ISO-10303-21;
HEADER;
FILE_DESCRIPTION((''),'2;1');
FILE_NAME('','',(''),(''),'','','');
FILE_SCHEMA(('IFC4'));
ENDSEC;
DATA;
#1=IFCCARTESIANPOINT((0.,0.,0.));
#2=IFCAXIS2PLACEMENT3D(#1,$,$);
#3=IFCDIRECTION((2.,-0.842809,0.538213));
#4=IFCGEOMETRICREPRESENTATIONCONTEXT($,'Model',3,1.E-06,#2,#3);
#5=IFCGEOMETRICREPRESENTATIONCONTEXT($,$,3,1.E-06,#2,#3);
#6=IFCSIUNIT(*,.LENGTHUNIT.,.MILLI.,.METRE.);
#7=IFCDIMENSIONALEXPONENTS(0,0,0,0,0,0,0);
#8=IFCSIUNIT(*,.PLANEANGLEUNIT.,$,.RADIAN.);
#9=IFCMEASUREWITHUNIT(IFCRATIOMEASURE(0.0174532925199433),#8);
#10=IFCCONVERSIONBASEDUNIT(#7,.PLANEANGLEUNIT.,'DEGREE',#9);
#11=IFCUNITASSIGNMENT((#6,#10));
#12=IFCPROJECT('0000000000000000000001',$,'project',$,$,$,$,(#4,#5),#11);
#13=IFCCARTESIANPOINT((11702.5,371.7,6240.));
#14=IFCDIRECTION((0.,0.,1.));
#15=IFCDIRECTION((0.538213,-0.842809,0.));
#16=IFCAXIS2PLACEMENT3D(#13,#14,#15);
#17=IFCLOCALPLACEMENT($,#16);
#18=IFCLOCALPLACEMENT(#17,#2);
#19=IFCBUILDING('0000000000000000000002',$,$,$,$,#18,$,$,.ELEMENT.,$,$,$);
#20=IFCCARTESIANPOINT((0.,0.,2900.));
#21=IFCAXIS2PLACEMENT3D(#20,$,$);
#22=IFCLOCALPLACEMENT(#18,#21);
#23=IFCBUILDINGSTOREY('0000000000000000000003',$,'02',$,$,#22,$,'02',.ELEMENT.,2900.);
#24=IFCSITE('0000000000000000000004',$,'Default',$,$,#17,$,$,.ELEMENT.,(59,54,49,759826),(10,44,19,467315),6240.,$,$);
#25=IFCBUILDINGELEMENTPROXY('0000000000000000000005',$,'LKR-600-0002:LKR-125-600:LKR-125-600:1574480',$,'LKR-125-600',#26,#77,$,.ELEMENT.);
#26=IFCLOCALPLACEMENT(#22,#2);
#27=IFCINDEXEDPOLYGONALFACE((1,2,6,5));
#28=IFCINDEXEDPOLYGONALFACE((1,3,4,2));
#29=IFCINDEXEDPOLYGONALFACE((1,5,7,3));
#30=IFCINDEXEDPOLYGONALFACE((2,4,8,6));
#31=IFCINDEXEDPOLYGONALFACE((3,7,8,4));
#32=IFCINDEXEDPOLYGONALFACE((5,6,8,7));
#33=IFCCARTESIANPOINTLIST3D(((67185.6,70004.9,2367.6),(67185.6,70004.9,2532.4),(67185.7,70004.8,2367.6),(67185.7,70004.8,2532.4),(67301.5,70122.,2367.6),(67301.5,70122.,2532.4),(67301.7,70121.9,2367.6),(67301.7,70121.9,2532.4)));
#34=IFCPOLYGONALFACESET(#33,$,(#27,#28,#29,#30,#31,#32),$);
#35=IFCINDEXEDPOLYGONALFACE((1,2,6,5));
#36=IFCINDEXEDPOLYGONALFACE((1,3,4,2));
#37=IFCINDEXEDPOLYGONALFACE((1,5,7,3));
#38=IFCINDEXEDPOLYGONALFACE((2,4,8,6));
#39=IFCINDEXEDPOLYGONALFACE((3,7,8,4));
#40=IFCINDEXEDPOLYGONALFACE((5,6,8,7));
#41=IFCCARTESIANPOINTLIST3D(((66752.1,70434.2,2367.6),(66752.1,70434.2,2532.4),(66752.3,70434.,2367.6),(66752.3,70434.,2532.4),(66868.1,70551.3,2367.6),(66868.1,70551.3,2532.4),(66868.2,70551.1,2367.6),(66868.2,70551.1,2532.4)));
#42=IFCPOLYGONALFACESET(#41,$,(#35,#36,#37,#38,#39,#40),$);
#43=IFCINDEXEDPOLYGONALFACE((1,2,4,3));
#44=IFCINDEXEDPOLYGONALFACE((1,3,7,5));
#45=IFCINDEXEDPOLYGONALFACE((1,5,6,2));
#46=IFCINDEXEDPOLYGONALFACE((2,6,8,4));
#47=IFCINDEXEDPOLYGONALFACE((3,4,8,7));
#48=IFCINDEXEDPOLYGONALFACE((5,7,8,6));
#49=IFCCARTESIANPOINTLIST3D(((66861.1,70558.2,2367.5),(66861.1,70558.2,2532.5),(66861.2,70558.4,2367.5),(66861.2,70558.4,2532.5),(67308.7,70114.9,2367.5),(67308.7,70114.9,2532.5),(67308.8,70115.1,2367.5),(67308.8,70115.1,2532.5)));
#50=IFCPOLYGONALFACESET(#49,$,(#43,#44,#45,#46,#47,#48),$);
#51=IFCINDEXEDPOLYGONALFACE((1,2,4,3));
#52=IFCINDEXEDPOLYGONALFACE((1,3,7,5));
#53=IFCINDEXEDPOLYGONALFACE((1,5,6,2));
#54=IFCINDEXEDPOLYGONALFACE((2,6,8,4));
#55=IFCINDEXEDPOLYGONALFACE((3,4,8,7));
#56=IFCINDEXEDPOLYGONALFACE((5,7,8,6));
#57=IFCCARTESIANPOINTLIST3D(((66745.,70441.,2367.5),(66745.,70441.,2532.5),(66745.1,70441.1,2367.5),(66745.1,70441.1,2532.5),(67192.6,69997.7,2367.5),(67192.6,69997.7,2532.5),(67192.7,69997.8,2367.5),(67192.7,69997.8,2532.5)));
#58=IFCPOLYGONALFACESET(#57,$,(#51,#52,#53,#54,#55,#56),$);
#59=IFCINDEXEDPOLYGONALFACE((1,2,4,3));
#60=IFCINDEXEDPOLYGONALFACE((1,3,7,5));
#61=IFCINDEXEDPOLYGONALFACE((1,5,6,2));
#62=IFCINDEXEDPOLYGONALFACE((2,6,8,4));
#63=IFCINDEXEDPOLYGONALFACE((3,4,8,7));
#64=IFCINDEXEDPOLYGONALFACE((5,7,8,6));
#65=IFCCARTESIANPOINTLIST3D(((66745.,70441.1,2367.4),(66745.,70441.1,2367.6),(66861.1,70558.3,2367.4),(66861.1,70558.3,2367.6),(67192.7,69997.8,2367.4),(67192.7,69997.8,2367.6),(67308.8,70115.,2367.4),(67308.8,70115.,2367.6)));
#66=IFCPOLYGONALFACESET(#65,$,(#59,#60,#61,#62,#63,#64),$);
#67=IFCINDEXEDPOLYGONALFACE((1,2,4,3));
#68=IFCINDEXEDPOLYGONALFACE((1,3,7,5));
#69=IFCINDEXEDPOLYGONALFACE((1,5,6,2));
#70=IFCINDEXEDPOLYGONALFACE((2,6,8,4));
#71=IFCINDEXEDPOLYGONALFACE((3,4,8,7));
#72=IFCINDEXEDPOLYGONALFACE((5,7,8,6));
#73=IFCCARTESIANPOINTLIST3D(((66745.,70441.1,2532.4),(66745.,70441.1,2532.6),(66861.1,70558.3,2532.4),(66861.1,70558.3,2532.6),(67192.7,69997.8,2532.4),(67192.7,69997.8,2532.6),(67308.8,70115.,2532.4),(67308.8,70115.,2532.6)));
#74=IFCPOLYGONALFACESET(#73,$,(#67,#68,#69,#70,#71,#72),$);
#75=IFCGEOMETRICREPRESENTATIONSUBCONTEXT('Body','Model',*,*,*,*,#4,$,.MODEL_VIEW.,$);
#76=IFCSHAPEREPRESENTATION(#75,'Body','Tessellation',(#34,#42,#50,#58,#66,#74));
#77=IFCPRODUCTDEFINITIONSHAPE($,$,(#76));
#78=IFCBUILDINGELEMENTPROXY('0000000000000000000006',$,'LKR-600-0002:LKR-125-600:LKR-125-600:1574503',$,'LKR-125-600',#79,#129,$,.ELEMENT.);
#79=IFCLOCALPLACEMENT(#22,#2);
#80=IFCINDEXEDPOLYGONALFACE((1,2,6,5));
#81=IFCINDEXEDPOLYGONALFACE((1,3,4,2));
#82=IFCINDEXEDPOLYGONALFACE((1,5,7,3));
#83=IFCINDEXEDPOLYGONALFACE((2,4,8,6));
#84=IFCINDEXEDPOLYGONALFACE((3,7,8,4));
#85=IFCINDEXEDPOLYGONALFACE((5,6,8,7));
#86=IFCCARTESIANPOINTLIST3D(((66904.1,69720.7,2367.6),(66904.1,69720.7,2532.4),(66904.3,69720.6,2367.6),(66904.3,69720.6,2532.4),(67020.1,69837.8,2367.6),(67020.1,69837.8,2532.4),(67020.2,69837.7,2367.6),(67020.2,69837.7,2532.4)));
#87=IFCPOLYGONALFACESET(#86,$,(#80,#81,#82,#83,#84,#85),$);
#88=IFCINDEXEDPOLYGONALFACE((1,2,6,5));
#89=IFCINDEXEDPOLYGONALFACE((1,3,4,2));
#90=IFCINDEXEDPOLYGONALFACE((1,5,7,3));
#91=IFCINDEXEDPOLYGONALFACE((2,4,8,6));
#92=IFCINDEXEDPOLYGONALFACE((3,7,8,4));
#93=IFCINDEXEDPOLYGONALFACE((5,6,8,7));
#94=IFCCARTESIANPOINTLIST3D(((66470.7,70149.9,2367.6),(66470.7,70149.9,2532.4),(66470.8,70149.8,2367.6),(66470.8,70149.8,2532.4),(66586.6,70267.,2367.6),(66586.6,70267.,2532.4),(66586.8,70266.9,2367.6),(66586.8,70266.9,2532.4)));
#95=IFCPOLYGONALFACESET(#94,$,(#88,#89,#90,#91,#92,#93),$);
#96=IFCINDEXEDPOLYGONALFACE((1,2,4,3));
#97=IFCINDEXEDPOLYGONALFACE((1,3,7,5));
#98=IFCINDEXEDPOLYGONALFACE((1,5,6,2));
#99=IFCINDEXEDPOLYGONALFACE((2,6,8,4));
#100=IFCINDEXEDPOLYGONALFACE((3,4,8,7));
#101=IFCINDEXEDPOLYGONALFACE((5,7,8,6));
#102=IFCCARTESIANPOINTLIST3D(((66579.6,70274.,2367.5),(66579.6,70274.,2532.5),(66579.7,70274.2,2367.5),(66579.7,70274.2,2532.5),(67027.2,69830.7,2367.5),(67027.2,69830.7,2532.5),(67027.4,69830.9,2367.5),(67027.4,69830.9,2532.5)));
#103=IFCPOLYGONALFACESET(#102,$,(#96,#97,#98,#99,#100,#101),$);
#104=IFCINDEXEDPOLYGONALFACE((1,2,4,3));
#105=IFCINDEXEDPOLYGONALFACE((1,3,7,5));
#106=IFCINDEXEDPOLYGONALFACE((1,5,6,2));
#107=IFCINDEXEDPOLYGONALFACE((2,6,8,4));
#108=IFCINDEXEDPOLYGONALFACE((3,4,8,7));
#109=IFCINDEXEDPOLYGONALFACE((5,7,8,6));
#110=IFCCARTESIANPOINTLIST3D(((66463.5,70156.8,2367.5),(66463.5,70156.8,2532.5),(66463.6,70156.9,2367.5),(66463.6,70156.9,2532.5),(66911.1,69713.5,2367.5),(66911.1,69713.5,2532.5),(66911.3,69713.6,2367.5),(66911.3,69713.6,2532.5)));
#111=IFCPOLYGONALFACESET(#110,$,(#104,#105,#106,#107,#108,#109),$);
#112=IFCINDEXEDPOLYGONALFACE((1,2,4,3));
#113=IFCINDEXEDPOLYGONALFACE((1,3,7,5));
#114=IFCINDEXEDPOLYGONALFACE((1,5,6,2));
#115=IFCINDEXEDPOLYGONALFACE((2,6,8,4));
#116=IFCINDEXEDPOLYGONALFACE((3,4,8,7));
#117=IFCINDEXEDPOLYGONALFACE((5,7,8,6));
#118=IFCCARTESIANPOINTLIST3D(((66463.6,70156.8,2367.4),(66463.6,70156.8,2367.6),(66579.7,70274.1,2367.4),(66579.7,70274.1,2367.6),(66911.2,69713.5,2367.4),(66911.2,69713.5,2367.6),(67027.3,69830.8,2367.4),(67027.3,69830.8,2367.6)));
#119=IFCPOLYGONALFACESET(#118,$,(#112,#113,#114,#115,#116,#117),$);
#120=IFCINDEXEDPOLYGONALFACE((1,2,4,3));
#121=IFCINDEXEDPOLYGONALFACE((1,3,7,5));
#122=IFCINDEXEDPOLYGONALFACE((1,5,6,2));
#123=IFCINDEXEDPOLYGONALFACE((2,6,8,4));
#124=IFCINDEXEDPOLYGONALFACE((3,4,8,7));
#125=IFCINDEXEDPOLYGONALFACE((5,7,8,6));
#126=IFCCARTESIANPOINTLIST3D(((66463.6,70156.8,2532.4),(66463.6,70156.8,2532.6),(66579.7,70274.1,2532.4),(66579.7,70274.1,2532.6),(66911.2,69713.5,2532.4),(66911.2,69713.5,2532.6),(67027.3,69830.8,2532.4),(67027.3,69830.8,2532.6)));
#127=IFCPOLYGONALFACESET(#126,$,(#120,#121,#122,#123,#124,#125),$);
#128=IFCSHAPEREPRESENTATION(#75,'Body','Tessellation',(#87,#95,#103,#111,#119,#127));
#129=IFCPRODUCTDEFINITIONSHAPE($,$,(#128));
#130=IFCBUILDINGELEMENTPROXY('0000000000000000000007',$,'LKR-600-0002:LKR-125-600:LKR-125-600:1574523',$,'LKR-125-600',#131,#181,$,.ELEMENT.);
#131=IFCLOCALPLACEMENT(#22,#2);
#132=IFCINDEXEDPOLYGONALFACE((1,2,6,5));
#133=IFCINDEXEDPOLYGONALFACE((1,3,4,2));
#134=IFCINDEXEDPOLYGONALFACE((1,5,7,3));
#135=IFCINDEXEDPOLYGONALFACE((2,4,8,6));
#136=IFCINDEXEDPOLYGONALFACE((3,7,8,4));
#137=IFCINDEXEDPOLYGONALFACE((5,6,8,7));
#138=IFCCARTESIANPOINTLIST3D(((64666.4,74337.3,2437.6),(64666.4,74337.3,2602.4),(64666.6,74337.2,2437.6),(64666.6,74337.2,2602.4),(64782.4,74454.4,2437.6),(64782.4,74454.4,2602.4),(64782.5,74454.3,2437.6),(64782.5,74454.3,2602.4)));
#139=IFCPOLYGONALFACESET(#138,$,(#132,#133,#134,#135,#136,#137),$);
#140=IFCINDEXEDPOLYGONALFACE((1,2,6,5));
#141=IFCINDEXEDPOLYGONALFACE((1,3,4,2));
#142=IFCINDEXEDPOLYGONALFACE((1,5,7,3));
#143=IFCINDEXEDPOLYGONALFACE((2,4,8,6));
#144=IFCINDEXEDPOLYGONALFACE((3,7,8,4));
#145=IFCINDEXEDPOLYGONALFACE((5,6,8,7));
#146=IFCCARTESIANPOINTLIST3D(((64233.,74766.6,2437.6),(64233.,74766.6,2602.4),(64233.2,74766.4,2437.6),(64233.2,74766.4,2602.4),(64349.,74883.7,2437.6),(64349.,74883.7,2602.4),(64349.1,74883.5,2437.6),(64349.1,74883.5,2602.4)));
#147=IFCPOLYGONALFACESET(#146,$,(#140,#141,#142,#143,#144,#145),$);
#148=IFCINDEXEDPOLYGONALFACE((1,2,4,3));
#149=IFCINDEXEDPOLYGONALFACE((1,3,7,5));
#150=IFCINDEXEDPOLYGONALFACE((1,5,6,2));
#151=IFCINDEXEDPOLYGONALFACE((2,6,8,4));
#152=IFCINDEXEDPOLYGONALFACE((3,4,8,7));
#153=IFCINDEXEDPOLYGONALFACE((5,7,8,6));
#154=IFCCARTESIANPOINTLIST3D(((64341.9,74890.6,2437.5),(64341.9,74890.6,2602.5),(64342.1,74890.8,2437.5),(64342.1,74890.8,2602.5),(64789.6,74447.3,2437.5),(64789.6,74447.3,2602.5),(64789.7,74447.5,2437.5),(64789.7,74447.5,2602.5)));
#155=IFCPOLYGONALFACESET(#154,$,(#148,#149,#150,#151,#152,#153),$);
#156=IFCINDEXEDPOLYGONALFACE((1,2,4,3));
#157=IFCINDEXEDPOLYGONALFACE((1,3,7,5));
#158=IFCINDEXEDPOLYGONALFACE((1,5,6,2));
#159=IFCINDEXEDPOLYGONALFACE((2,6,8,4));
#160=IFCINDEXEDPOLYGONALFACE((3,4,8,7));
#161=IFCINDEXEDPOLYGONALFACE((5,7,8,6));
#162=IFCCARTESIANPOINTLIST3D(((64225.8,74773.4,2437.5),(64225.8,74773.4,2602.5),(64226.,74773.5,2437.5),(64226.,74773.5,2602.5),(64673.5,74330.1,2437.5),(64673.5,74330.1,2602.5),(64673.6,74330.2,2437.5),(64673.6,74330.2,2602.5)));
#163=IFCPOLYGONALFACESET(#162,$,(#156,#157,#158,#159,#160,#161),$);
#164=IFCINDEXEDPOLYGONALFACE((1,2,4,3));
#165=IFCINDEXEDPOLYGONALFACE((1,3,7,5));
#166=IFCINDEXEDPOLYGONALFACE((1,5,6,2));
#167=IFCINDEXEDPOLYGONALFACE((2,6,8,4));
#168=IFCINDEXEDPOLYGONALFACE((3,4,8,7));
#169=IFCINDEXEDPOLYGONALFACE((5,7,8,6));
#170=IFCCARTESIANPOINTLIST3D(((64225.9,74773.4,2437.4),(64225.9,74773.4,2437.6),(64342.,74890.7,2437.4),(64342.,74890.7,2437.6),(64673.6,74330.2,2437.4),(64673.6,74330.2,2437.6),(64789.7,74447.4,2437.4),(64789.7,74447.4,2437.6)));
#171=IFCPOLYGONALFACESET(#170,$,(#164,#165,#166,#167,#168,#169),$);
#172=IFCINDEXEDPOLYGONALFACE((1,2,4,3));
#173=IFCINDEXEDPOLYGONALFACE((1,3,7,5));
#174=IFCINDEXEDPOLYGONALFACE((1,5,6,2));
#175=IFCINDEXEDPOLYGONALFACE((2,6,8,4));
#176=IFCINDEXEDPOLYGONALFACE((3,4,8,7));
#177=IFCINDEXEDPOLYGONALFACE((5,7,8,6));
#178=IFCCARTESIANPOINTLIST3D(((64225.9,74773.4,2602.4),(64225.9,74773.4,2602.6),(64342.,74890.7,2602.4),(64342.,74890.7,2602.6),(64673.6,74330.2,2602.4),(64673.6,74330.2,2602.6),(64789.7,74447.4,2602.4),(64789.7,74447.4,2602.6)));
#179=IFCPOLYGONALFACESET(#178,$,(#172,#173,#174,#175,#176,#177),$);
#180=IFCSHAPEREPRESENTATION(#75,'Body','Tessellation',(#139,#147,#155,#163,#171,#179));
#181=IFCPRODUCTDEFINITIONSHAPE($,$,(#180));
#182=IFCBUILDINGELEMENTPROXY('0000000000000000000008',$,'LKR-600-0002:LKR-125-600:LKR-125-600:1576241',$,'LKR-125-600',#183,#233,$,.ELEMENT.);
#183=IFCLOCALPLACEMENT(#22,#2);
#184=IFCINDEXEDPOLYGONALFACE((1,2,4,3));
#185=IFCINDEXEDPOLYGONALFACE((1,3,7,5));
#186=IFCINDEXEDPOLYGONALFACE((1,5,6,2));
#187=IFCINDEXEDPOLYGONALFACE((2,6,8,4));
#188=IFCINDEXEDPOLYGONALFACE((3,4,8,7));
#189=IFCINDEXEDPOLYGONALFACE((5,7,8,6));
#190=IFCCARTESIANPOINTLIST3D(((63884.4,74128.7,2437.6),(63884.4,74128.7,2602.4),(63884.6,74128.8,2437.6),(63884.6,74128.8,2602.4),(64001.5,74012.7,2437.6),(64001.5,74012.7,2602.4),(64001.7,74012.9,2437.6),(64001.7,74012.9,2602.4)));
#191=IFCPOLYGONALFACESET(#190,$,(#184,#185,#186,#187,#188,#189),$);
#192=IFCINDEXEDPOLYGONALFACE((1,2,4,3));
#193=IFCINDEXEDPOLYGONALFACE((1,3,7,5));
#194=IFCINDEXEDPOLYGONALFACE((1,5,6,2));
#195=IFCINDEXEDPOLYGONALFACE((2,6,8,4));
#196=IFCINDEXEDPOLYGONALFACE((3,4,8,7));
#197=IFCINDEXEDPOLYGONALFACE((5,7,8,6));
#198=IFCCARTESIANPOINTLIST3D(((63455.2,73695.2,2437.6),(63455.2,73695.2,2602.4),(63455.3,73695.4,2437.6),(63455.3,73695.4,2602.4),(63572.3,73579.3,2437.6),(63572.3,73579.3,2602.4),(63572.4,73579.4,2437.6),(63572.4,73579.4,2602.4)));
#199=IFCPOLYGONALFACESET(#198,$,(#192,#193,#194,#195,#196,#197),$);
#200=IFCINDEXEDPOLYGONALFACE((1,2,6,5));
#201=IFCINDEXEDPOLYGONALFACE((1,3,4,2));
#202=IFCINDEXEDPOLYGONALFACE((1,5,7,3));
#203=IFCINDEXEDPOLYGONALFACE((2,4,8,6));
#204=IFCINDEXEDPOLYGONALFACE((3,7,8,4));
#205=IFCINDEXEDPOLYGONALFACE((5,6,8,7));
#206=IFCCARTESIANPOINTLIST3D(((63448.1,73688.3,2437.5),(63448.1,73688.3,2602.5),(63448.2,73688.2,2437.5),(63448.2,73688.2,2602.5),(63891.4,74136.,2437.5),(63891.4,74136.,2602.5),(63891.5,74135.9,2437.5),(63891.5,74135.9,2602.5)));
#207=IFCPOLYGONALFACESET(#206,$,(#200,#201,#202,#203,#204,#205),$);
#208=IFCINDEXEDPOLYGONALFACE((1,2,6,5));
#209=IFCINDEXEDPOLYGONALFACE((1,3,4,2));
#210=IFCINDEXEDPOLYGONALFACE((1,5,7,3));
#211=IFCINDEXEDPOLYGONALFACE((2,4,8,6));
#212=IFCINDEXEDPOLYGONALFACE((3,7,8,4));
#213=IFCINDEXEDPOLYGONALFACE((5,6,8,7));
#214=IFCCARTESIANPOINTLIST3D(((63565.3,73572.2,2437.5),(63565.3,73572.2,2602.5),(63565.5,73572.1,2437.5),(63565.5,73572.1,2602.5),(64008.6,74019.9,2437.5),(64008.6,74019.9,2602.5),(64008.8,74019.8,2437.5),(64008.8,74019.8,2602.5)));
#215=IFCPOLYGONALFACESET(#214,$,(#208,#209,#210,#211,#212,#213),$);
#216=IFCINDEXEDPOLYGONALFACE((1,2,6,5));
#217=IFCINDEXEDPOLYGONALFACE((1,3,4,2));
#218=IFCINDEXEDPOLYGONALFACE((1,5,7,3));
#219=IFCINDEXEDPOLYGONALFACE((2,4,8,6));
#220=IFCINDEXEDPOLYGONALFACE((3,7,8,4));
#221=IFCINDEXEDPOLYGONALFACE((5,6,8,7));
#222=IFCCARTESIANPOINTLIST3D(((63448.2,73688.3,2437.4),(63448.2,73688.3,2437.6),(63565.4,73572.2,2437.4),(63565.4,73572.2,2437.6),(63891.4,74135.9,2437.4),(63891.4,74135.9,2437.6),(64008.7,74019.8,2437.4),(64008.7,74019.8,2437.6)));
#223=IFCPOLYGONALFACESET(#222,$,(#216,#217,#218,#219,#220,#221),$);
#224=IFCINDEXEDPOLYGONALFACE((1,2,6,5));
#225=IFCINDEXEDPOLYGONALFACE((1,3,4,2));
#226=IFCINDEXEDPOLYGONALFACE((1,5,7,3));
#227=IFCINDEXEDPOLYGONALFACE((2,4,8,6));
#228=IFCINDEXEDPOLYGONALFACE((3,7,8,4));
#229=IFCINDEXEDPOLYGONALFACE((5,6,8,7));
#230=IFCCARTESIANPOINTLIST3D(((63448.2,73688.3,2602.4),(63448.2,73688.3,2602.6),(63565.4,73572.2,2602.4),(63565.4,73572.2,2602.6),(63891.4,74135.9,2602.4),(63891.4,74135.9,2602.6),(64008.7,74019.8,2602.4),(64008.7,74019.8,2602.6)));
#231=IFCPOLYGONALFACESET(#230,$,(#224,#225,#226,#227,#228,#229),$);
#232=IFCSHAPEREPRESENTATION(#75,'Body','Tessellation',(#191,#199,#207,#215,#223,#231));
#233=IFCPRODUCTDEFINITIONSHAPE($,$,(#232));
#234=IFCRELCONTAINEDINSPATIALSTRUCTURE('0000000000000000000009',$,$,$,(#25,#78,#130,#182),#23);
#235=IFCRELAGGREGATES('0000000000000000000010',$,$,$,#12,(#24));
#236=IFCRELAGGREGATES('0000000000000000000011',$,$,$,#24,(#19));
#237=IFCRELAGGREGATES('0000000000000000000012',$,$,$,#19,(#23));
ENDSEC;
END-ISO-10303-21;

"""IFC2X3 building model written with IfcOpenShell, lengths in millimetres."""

from ifc_helpers import new_model, entity, si_unit, converted_unit, direction, frame, frame_2d, origin, place, context, subcontext, project, spatial, rectangle, extrude, source, transform, mapped, element, save


model = new_model("IFC2X3")

# Units and contexts
model_context = context("Model", 3, precision=1e-06, world=origin(), true_north=direction((2.0, -0.842809, 0.538213)))
context_of_model = context(None, 3, precision=1e-06, world=origin(), true_north=direction((2.0, -0.842809, 0.538213)))
body_context = subcontext(model_context, "Body", "Model", "MODEL_VIEW")
ifc_project = project(units=[si_unit("LENGTHUNIT", "METRE", prefix="MILLI"), converted_unit("PLANEANGLEUNIT", "DEGREE", entity("IfcRatioMeasure", 0.0174532925199433), si_unit("PLANEANGLEUNIT", "RADIAN"), dimensions=[0, 0, 0, 0, 0, 0, 0])], contexts=[model_context, context_of_model])

# Site, building, storey
site_placement = place(None, frame((11702.5, 371.7, 6240.0), z_axis=(0.0, 0.0, 1.0), x_axis=(0.538213, -0.842809, 0.0)))
site = spatial("IfcSite", under=ifc_project, at=site_placement, Name="Default", CompositionType="ELEMENT", RefLatitude=(59, 54, 49, 759826), RefLongitude=(10, 44, 19, 467315), RefElevation=6240.0)
building_placement = place(site_placement, origin())
building = spatial("IfcBuilding", under=site, at=building_placement, CompositionType="ELEMENT")
storey_placement = place(building_placement, frame((0.0, 0.0, 2900.0)))
storey = spatial("IfcBuildingStorey", under=building, at=storey_placement, Name="02", LongName="02", CompositionType="ELEMENT", Elevation=2900.0)

# Building element proxies
shared_shape_1 = source(origin(), body_context, "Body", "SweptSolid", [
    extrude(rectangle(XDim=0.2, YDim=164.8, at=frame_2d((0.0, 0.0), x_axis=(1.0, 0.0))), frame((305.0, 0.0, -82.4)), (0.0, 0.0, 1.0), 164.8),
    extrude(rectangle(XDim=0.2, YDim=164.8, at=frame_2d((0.0, 0.0), x_axis=(1.0, 0.0))), frame((-305.0, 0.0, -82.4)), (0.0, 0.0, 1.0), 164.8),
    extrude(rectangle(XDim=0.2, YDim=630.0, at=frame_2d((0.0, 0.0), x_axis=(1.0, 0.0))), frame((0.0, 82.5, -82.5), z_axis=(0.0, 0.0, 1.0), x_axis=(0.0, 1.0, 0.0)), (0.0, 0.0, 1.0), 165.0),
    extrude(rectangle(XDim=0.2, YDim=630.0, at=frame_2d((0.0, 0.0), x_axis=(1.0, 0.0))), frame((0.0, -82.5, -82.5), z_axis=(0.0, 0.0, 1.0), x_axis=(0.0, 1.0, 0.0)), (0.0, 0.0, 1.0), 165.0),
    extrude(rectangle(XDim=165.0, YDim=630.0, at=frame_2d((0.0, 0.0), x_axis=(1.0, 0.0))), frame((0.0, 0.0, -82.6), z_axis=(0.0, 0.0, 1.0), x_axis=(0.0, -1.0, 0.0)), (0.0, 0.0, 1.0), 0.2),
    extrude(rectangle(XDim=165.0, YDim=630.0, at=frame_2d((0.0, 0.0), x_axis=(1.0, 0.0))), frame((0.0, 0.0, 82.4), z_axis=(0.0, 0.0, 1.0), x_axis=(0.0, -1.0, 0.0)), (0.0, 0.0, 1.0), 0.2),
])
for number, where, z_axis, x_axis, name in (
    (1, (67026.9, 70278.0, 2450.0), (0.0, 0.0, 1.0), (0.710554, -0.703643, 0.0), "LKR-600-0002:LKR-125-600:LKR-125-600:1574480"),
    (2, (66745.4, 69993.8, 2450.0), (0.0, 0.0, 1.0), (0.710554, -0.703643, 0.0), "LKR-600-0002:LKR-125-600:LKR-125-600:1574503"),
    (3, (64507.8, 74610.4, 2520.0), (0.0, 0.0, 1.0), (0.710554, -0.703643, 0.0), "LKR-600-0002:LKR-125-600:LKR-125-600:1574523"),
    (4, (63728.4, 73854.1, 2520.0), (0.0, 0.0, 1.0), (0.703643, 0.710554, 0.0), "LKR-600-0002:LKR-125-600:LKR-125-600:1576241"),
):
    element("IfcBuildingElementProxy", number, at=place(storey_placement, frame(where, z_axis=z_axis, x_axis=x_axis)), inside=storey, Name=name, ObjectType="LKR-125-600", CompositionType="ELEMENT", context=body_context, shape_type="MappedRepresentation", body=[
        mapped(shared_shape_1, transform((0.0, 0.0, 0.0), scale=1.0)),
    ])

save(model, "model.ifc")
